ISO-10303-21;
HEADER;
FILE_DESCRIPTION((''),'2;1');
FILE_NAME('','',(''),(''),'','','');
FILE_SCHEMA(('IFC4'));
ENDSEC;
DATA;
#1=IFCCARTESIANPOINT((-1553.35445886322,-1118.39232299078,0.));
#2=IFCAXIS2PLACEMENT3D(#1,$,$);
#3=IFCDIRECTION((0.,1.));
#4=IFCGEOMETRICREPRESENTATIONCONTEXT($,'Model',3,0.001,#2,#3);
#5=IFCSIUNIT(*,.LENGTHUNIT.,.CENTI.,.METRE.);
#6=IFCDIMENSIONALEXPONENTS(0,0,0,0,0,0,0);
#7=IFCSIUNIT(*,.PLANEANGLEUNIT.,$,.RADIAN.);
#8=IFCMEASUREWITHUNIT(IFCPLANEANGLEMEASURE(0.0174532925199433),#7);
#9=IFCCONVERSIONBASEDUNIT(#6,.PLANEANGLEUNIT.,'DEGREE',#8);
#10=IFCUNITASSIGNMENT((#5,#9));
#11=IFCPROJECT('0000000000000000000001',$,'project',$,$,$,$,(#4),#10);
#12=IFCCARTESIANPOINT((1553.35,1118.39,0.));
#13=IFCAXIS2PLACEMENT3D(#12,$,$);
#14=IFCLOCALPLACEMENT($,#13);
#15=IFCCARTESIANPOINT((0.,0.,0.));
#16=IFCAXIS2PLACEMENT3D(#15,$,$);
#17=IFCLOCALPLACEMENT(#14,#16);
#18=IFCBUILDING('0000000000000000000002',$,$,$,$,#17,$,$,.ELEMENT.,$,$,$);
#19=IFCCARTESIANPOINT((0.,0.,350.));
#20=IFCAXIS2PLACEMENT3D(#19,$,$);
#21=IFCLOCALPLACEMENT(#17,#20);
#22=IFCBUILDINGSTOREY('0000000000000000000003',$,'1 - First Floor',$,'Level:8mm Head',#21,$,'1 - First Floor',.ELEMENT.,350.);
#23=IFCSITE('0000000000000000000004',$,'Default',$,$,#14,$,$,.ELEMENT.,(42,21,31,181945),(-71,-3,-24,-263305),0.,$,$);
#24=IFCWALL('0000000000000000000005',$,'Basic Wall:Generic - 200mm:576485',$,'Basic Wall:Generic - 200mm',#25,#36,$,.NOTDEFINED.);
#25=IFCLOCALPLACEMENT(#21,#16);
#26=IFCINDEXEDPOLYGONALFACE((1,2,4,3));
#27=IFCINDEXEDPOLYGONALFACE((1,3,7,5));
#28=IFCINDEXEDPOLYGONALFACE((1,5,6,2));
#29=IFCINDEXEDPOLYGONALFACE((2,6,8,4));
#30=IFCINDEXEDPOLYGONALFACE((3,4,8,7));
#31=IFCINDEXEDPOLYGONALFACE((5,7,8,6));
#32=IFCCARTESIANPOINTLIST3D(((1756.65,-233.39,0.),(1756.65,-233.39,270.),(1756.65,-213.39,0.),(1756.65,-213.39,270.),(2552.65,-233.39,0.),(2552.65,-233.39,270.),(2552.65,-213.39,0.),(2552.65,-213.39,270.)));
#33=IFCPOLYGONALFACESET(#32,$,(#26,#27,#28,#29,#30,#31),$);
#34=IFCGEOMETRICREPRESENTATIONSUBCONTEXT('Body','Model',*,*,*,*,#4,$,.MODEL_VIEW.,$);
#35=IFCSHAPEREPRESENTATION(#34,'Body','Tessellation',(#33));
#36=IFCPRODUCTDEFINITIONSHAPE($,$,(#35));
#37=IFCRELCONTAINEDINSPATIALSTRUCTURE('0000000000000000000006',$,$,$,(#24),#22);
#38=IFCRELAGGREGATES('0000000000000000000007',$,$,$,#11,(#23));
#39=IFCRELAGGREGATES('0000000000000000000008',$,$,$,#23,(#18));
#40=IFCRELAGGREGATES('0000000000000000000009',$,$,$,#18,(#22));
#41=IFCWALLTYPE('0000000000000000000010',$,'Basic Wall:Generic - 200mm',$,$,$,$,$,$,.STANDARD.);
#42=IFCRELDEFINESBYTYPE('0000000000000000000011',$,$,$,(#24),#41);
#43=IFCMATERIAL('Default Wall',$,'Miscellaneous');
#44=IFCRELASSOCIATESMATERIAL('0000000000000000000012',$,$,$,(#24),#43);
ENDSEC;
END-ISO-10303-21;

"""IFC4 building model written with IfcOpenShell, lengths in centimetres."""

from ifc_helpers import new_model, entity, si_unit, converted_unit, direction, frame, origin, place, context, subcontext, project, spatial, indexed_curve, outline, extrude, material, type_object, element, save


model = new_model("IFC4")

# Units and contexts
model_context = context("Model", 3, precision=0.001, world=frame((-1553.35445886322, -1118.39232299078, 0.0)), true_north=direction((0.0, 1.0)))
body_context = subcontext(model_context, "Body", "Model", "MODEL_VIEW")
ifc_project = project(units=[si_unit("LENGTHUNIT", "METRE", prefix="CENTI"), converted_unit("PLANEANGLEUNIT", "DEGREE", entity("IfcPlaneAngleMeasure", 0.0174532925199433), si_unit("PLANEANGLEUNIT", "RADIAN"), dimensions=[0, 0, 0, 0, 0, 0, 0])], contexts=[model_context])

# Site, building, storey
site_placement = place(None, frame((1553.35, 1118.39, 0.0)))
site = spatial("IfcSite", under=ifc_project, at=site_placement, Name="Default", CompositionType="ELEMENT", RefLatitude=(42, 21, 31, 181945), RefLongitude=(-71, -3, -24, -263305), RefElevation=0.0)
building_placement = place(site_placement, origin())
building = spatial("IfcBuilding", under=site, at=building_placement, CompositionType="ELEMENT")
storey_placement = place(building_placement, frame((0.0, 0.0, 350.0)))
storey = spatial("IfcBuildingStorey", under=building, at=storey_placement, Name="1 - First Floor", ObjectType="Level:8mm Head", LongName="1 - First Floor", CompositionType="ELEMENT", Elevation=350.0)

# Wall
ifc_material_1 = material(Name="Default Wall", Category="Miscellaneous")
wall_type_1 = type_object("IfcWallType", Name="Basic Wall:Generic - 200mm", PredefinedType="STANDARD")
wall_1_placement = place(storey_placement, frame((1756.65, -223.39, 0.0)))
element("IfcWall", 1, at=wall_1_placement, inside=storey, type_object=wall_type_1, material=ifc_material_1, Name="Basic Wall:Generic - 200mm:576485", ObjectType="Basic Wall:Generic - 200mm", PredefinedType="NOTDEFINED", context=body_context, shape_type="SweptSolid", body=[
    extrude(outline(indexed_curve([(796.0, 10.0), (0.0, 10.0), (0.0, -10.0), (796.0, -10.0), (796.0, 10.0)], self_intersect=False)), origin(), (0.0, 0.0, 1.0), 270.0),
])

save(model, "model.ifc")
